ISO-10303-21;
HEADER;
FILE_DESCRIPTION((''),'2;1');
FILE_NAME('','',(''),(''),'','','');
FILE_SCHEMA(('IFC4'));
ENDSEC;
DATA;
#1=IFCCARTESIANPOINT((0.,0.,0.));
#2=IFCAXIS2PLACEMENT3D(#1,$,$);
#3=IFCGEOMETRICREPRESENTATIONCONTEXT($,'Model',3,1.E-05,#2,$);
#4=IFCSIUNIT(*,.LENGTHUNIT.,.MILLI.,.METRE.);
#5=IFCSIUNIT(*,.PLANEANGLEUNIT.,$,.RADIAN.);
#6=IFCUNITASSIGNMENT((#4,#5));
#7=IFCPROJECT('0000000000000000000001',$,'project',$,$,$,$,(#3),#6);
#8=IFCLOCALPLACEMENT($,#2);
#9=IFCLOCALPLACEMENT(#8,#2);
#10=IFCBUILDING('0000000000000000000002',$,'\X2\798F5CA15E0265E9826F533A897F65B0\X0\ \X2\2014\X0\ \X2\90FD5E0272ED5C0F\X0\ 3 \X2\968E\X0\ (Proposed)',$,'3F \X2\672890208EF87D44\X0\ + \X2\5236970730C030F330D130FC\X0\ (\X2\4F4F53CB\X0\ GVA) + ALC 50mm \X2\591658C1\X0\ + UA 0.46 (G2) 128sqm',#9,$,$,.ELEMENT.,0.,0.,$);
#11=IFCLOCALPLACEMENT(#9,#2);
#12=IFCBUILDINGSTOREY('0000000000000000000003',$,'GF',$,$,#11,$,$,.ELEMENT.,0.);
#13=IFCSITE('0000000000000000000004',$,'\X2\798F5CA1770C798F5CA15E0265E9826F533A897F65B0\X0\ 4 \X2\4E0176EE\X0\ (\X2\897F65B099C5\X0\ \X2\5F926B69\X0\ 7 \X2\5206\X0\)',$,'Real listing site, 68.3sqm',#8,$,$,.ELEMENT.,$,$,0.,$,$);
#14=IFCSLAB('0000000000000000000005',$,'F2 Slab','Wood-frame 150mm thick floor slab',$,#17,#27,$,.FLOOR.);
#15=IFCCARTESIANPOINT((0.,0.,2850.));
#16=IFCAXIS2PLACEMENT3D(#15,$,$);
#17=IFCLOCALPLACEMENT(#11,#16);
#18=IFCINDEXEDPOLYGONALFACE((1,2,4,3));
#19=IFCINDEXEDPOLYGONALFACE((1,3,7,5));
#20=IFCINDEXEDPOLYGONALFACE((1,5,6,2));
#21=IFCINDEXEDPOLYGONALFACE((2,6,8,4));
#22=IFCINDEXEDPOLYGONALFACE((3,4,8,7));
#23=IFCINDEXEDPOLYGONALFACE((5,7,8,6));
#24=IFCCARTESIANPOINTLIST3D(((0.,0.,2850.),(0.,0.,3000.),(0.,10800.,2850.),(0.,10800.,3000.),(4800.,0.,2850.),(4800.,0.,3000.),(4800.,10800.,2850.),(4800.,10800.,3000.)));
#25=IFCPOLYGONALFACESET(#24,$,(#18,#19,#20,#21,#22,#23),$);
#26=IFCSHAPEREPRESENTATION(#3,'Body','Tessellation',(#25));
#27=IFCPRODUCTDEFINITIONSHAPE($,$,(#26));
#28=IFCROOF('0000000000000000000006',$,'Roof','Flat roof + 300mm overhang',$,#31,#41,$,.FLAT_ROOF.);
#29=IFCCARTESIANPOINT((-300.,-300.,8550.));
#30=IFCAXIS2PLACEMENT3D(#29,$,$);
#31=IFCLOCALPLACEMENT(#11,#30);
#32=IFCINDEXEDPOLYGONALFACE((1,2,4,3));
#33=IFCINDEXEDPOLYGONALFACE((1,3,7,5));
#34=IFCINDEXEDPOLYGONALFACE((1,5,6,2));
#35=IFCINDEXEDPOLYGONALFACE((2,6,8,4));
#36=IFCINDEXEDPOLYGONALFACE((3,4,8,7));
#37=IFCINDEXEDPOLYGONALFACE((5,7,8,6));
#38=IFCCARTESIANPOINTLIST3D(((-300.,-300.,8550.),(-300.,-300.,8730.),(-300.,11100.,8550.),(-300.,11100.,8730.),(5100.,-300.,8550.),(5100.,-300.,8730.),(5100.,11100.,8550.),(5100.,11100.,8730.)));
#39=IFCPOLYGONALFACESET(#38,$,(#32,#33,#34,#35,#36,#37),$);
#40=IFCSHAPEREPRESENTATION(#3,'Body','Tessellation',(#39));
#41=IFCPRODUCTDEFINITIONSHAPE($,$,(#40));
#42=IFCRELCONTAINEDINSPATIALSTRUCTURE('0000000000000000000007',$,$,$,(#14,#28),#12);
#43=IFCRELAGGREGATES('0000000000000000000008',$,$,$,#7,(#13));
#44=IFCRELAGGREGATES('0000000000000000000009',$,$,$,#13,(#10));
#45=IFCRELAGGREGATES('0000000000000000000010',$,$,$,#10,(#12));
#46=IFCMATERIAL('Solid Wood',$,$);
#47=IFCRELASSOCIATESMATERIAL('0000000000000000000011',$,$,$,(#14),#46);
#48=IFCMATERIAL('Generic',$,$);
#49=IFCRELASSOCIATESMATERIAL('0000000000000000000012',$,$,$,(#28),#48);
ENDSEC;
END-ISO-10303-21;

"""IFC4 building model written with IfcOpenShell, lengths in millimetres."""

from ifc_helpers import new_model, si_unit, frame, frame_2d, origin, place, context, project, spatial, rectangle, extrude, material, element, save


model = new_model("IFC4")

# Units and contexts
model_context = context("Model", 3, precision=1e-05, world=origin())
ifc_project = project(units=[si_unit("LENGTHUNIT", "METRE", prefix="MILLI"), si_unit("PLANEANGLEUNIT", "RADIAN")], contexts=[model_context])

# Site, building, storey
site_placement = place(None, origin())
site = spatial("IfcSite", under=ifc_project, at=site_placement, Name="福岡県福岡市早良区西新 4 丁目 (西新駅 徒歩 7 分)", ObjectType="Real listing site, 68.3sqm", CompositionType="ELEMENT", RefElevation=0.0)
building_placement = place(site_placement, origin())
building = spatial("IfcBuilding", under=site, at=building_placement, Name="福岡市早良区西新 — 都市狭小 3 階 (Proposed)", ObjectType="3F 木造軸組 + 制震ダンパー (住友 GVA) + ALC 50mm 外壁 + UA 0.46 (G2) 128sqm", CompositionType="ELEMENT", ElevationOfRefHeight=0.0, ElevationOfTerrain=0.0)
storey_placement = place(building_placement, origin())
storey = spatial("IfcBuildingStorey", under=building, at=storey_placement, Name="GF", CompositionType="ELEMENT", Elevation=0.0)

# Slab
ifc_material_1 = material(Name="Solid Wood")
slab_1_placement = place(storey_placement, frame((0.0, 0.0, 2850.0)))
element("IfcSlab", 1, at=slab_1_placement, inside=storey, material=ifc_material_1, Name="F2 Slab", Description="Wood-frame 150mm thick floor slab", PredefinedType="FLOOR", context=model_context, shape_type="SweptSolid", body=[
    extrude(rectangle(XDim=4800.0, YDim=10800.0, at=frame_2d((2400.0, 5400.0))), frame((0.0, 0.0, 2850.0)), (0.0, 0.0, 1.0), 150.0),
])

# Shared definitions
ifc_material_2 = material(Name="Generic")

# Roof
roof_placement = place(storey_placement, frame((-300.0, -300.0, 8550.0)))
element("IfcRoof", 2, at=roof_placement, inside=storey, material=ifc_material_2, Name="Roof", Description="Flat roof + 300mm overhang", PredefinedType="FLAT_ROOF", context=model_context, shape_type="SweptSolid", body=[
    extrude(rectangle(XDim=5400.0, YDim=11400.0, at=frame_2d((2700.0, 5700.0))), frame((-300.0, -300.0, 8550.0)), (0.0, 0.0, 1.0), 180.0),
])

save(model, "model.ifc")
